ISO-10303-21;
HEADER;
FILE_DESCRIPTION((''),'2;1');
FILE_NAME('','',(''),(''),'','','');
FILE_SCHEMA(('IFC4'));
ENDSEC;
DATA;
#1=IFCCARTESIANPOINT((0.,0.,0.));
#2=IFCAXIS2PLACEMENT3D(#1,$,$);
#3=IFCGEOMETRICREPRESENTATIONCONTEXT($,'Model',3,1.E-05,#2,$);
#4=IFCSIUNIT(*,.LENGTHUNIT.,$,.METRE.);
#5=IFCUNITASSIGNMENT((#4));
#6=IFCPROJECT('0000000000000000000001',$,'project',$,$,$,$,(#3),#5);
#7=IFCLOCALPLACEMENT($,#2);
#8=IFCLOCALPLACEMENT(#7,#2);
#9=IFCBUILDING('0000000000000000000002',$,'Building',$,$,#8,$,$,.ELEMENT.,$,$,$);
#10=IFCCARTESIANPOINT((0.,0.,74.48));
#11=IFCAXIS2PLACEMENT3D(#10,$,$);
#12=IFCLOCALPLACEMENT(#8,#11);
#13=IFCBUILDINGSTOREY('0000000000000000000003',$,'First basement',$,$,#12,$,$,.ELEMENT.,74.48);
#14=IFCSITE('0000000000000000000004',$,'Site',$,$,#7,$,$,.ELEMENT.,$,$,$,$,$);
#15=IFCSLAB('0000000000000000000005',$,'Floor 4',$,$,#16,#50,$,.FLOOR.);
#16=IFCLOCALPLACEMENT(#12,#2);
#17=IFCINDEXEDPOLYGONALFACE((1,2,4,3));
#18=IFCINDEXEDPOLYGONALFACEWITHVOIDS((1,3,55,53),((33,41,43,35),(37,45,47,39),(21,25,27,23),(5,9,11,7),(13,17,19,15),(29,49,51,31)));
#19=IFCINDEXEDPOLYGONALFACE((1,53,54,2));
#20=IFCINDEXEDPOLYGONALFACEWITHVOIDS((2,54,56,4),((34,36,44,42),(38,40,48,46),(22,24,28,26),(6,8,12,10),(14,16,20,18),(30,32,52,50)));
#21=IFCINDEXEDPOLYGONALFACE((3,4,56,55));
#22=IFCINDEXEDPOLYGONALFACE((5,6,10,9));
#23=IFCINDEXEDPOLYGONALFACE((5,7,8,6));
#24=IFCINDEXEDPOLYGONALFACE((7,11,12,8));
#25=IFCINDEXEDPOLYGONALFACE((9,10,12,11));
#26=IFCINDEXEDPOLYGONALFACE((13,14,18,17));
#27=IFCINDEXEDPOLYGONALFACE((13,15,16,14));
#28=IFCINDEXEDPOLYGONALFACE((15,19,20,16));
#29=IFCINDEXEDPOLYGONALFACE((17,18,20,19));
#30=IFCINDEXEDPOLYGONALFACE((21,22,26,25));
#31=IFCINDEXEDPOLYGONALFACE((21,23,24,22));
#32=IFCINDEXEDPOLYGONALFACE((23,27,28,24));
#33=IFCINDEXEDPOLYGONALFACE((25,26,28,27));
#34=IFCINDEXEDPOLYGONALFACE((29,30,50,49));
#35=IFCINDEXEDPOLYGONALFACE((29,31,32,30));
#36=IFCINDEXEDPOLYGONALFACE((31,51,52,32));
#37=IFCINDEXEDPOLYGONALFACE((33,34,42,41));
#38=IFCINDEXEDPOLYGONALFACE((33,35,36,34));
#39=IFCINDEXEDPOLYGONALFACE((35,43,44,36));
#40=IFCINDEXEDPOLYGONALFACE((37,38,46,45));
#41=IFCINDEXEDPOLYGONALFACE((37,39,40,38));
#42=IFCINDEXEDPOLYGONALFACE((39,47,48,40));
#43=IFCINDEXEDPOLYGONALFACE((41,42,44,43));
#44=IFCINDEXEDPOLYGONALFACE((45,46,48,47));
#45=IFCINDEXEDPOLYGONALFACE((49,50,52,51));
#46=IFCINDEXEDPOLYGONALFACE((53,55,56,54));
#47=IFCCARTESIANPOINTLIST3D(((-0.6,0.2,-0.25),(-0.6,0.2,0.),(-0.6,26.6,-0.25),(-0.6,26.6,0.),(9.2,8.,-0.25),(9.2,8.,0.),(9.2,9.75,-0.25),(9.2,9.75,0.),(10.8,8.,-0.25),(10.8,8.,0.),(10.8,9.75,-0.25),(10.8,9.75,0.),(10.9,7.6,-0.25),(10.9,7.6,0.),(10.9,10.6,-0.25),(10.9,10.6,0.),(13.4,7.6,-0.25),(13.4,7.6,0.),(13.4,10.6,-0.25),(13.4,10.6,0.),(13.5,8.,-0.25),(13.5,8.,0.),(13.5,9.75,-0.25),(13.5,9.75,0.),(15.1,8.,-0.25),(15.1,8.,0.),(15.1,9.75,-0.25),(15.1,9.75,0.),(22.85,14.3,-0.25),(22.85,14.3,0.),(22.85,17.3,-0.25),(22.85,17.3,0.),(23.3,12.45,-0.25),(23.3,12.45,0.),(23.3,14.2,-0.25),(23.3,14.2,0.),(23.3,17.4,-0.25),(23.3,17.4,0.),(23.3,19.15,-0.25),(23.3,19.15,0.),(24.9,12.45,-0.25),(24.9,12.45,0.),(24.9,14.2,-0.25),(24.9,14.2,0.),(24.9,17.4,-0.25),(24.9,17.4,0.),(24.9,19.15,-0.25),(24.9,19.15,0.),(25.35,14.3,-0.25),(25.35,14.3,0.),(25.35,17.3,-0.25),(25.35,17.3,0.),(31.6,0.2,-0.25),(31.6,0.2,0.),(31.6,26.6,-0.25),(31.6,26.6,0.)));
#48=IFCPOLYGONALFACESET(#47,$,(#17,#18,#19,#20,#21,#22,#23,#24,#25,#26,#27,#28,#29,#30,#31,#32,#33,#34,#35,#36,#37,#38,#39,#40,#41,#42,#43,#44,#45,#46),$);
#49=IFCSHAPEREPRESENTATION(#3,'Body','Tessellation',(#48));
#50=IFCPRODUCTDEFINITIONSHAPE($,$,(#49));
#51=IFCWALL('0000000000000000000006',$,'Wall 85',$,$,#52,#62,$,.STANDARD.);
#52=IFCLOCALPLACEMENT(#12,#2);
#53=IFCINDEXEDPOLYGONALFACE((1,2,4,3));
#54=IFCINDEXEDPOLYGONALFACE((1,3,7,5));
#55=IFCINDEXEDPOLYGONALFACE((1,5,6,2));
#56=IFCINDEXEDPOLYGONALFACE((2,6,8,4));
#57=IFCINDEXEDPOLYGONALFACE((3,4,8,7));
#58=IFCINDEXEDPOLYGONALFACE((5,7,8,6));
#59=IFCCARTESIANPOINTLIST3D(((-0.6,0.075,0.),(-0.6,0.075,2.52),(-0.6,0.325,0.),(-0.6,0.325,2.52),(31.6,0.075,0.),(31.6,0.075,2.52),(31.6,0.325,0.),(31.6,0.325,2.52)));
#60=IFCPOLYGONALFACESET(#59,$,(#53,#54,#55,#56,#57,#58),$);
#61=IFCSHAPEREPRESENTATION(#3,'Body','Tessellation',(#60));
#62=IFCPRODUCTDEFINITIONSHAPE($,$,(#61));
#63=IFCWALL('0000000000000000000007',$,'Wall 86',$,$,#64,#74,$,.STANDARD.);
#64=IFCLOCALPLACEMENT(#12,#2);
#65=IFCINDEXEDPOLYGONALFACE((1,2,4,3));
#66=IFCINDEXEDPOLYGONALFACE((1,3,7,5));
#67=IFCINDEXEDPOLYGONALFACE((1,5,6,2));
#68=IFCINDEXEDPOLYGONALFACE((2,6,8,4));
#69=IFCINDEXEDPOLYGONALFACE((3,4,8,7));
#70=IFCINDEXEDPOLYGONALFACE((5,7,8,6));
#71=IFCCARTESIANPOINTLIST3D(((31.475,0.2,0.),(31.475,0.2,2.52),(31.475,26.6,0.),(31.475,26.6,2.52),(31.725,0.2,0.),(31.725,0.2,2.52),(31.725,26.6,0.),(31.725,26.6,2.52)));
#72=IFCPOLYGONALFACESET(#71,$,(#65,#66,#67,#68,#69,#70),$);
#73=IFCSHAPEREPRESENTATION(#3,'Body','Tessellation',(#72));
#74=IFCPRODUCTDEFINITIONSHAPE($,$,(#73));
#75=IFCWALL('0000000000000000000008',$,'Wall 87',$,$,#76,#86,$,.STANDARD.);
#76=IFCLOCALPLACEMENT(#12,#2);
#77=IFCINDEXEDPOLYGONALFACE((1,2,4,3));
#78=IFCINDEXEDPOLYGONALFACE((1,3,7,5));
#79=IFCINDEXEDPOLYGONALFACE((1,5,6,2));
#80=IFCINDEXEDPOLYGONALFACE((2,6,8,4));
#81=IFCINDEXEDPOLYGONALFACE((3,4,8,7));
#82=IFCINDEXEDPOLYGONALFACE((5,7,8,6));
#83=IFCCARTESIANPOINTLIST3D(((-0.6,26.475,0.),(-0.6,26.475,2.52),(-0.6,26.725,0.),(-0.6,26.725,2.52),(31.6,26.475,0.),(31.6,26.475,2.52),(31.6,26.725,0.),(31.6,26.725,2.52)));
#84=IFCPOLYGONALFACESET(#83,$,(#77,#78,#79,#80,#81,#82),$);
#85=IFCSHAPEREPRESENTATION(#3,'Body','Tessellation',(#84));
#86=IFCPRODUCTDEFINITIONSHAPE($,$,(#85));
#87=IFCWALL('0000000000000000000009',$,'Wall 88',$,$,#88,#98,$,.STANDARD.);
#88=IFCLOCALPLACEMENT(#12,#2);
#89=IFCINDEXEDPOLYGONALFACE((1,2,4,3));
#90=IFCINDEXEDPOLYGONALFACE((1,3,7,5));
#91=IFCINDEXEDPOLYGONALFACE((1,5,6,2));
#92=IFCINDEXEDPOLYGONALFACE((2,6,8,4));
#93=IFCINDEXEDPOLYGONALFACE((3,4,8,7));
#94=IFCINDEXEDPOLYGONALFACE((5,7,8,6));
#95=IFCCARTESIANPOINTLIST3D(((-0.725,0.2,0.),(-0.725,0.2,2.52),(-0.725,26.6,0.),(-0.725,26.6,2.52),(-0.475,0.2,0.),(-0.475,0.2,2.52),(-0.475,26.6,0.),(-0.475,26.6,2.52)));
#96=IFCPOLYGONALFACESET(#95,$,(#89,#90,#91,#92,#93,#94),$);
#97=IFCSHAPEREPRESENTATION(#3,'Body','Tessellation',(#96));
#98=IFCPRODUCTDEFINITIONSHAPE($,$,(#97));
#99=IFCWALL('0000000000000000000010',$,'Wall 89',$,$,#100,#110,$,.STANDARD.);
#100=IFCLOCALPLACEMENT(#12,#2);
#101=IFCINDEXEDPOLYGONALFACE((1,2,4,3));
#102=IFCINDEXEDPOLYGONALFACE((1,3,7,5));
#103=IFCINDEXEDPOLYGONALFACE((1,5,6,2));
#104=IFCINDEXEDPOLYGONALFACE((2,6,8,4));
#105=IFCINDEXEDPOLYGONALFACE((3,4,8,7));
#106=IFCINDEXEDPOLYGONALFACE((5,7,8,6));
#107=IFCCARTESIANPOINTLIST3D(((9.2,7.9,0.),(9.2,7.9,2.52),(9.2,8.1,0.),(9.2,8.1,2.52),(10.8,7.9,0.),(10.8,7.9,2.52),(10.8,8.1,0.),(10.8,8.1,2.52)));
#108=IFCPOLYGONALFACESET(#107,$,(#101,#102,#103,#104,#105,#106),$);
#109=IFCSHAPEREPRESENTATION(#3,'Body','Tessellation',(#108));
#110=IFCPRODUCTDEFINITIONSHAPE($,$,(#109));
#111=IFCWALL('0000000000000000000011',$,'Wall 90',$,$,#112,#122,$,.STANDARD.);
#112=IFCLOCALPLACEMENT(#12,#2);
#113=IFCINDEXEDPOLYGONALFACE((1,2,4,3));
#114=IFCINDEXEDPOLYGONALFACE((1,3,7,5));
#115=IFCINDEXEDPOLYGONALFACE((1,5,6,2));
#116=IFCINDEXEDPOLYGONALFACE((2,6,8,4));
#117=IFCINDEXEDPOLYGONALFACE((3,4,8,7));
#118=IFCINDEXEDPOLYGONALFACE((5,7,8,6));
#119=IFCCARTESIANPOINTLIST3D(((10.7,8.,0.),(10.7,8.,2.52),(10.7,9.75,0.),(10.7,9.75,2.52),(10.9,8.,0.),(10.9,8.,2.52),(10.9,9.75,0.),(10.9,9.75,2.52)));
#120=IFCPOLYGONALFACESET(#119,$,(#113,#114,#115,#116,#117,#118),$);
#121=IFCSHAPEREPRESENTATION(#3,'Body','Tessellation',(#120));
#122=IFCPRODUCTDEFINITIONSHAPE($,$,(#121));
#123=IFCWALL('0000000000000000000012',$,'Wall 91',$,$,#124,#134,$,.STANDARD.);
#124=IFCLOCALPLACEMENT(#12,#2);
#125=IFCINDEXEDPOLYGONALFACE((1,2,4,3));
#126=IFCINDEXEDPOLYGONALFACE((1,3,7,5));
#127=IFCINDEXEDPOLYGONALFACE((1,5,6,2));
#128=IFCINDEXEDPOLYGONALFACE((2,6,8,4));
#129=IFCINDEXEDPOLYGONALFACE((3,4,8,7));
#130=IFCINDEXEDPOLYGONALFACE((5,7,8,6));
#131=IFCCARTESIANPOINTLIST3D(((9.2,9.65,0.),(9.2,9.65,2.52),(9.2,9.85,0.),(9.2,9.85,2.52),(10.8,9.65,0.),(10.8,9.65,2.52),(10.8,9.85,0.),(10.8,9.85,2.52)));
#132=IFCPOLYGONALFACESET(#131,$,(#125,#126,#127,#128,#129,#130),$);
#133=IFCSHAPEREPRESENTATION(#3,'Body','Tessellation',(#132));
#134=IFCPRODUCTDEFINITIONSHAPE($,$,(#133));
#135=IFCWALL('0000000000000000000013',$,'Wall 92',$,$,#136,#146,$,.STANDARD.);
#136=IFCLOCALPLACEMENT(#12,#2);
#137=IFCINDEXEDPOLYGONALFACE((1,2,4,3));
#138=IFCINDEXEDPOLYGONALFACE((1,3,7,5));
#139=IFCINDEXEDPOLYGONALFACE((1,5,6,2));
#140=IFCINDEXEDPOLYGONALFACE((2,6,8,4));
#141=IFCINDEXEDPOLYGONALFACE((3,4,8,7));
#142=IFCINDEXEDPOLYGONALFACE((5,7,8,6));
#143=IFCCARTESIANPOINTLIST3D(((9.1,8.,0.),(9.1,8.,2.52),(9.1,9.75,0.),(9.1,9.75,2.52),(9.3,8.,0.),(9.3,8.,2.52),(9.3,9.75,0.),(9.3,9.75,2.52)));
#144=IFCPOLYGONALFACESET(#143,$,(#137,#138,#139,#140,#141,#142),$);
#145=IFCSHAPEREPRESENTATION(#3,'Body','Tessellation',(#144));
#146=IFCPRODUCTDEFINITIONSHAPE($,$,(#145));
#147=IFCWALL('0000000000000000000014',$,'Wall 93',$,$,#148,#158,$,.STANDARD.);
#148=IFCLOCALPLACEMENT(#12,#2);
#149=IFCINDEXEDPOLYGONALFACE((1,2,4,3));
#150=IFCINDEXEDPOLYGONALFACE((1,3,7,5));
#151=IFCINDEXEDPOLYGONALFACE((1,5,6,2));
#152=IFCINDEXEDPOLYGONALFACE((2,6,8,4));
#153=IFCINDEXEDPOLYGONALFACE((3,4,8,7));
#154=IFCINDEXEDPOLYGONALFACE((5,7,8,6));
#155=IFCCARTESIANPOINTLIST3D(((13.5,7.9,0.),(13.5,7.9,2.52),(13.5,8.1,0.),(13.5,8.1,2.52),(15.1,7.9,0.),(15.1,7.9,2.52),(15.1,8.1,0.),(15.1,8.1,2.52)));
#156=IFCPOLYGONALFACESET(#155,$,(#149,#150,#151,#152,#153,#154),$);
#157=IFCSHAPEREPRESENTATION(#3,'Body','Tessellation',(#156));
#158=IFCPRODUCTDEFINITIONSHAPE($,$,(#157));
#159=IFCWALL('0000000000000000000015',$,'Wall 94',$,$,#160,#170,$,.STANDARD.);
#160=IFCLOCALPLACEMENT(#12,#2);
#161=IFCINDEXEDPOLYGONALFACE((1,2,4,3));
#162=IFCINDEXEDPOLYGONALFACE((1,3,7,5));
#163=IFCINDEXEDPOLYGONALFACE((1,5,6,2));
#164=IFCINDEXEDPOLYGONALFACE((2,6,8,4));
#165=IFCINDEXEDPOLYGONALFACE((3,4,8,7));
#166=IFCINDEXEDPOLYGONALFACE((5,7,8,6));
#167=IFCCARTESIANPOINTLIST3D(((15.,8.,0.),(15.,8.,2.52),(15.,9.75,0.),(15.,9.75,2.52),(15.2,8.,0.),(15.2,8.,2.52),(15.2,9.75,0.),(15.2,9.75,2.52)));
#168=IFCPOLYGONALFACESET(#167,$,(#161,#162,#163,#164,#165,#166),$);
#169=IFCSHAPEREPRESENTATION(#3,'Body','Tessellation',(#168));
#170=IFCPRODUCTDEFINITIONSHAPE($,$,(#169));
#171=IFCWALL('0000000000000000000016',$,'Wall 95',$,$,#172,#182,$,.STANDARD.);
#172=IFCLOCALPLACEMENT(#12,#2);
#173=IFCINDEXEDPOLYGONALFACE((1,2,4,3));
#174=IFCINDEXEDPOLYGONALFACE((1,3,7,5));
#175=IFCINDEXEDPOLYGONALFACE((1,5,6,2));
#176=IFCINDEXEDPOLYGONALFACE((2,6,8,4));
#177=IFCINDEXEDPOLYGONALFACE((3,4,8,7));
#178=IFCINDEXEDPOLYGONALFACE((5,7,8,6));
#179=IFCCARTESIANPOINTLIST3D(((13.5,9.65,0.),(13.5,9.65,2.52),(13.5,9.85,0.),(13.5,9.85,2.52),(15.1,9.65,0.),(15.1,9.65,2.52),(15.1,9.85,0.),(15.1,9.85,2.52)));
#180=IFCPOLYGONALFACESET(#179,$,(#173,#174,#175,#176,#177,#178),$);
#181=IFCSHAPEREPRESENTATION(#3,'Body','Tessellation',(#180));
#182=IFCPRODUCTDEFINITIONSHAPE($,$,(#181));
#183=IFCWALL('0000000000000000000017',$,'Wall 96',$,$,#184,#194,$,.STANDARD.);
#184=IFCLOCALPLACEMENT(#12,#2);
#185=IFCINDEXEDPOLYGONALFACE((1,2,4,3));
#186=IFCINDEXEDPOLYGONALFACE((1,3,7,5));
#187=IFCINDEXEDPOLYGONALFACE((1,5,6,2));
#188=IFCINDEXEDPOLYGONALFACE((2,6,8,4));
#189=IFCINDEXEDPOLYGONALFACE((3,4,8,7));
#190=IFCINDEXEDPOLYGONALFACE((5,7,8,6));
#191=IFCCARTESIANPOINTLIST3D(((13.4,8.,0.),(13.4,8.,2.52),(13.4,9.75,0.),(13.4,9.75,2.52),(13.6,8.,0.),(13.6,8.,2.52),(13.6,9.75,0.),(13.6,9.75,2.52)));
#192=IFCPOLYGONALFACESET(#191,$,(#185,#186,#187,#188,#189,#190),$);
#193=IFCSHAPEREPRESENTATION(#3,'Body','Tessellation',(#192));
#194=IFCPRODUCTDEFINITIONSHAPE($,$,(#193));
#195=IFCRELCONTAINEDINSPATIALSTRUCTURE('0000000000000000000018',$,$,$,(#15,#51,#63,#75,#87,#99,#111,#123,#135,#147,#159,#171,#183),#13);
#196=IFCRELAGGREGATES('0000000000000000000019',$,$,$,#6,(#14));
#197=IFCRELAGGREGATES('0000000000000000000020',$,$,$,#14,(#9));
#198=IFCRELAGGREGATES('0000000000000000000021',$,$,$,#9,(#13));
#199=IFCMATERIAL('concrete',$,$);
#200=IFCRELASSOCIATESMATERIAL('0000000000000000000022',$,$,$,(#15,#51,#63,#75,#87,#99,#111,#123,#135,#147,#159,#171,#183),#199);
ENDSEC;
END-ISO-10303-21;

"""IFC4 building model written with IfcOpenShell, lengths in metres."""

from ifc_helpers import new_model, si_unit, frame, frame_2d, origin, place, context, project, spatial, polyline, rectangle, outline, extrude, material, element, save


model = new_model("IFC4")

# Units and contexts
model_context = context("Model", 3, precision=1e-05, world=origin())
ifc_project = project(units=[si_unit("LENGTHUNIT", "METRE")], contexts=[model_context])

# Site, building, storey
site_placement = place(None, origin())
site = spatial("IfcSite", under=ifc_project, at=site_placement, Name="Site", CompositionType="ELEMENT")
building_placement = place(site_placement, origin())
building = spatial("IfcBuilding", under=site, at=building_placement, Name="Building", CompositionType="ELEMENT")
storey_placement = place(building_placement, frame((0.0, 0.0, 74.48)))
storey = spatial("IfcBuildingStorey", under=building, at=storey_placement, Name="First basement", CompositionType="ELEMENT", Elevation=74.48)

# Slab
ifc_material = material(Name="concrete")
slab_placement = place(storey_placement, frame((0.0, 0.0, -0.25), z_axis=(0.0, 0.0, 1.0), x_axis=(1.0, 0.0, 0.0)))
element("IfcSlab", 1, at=slab_placement, inside=storey, material=ifc_material, Name="Floor 4", PredefinedType="FLOOR", context=model_context, shape_type="SweptSolid", body=[
    extrude(outline(polyline([(-0.6, 0.2), (31.6, 0.2), (31.6, 26.6), (-0.6, 26.6), (-0.6, 0.2)]), holes=[polyline([(10.9, 7.6), (13.4, 7.6), (13.4, 10.6), (10.9, 10.6), (10.9, 7.6)]), polyline([(9.2, 8.0), (10.8, 8.0), (10.8, 9.75), (9.2, 9.75), (9.2, 8.0)]), polyline([(13.5, 8.0), (15.1, 8.0), (15.1, 9.75), (13.5, 9.75), (13.5, 8.0)]), polyline([(22.85, 14.3), (25.35, 14.3), (25.35, 17.3), (22.85, 17.3), (22.85, 14.3)]), polyline([(23.3, 17.4), (24.9, 17.4), (24.9, 19.15), (23.3, 19.15), (23.3, 17.4)]), polyline([(23.3, 12.45), (24.9, 12.45), (24.9, 14.2), (23.3, 14.2), (23.3, 12.45)])]), origin(), (0.0, 0.0, 1.0), 0.25),
])

# Walls
wall_1_placement = place(storey_placement, frame((-0.6, 0.2, 0.0), z_axis=(0.0, 0.0, 1.0), x_axis=(1.0, 0.0, 0.0)))
element("IfcWall", 2, at=wall_1_placement, inside=storey, material=ifc_material, Name="Wall 85", PredefinedType="STANDARD", context=model_context, shape_type="SweptSolid", body=[
    extrude(rectangle(XDim=32.2, YDim=0.25, at=frame_2d((16.1, 0.0))), origin(), (0.0, 0.0, 1.0), 2.52),
])
wall_2_placement = place(storey_placement, frame((31.6, 0.2, 0.0), z_axis=(0.0, 0.0, 1.0), x_axis=(0.0, 1.0, 0.0)))
element("IfcWall", 3, at=wall_2_placement, inside=storey, material=ifc_material, Name="Wall 86", PredefinedType="STANDARD", context=model_context, shape_type="SweptSolid", body=[
    extrude(rectangle(XDim=26.4, YDim=0.25, at=frame_2d((13.2, 0.0))), origin(), (0.0, 0.0, 1.0), 2.52),
])
wall_3_placement = place(storey_placement, frame((31.6, 26.6, 0.0), z_axis=(0.0, 0.0, 1.0), x_axis=(-1.0, 0.0, 0.0)))
element("IfcWall", 4, at=wall_3_placement, inside=storey, material=ifc_material, Name="Wall 87", PredefinedType="STANDARD", context=model_context, shape_type="SweptSolid", body=[
    extrude(rectangle(XDim=32.2, YDim=0.25, at=frame_2d((16.1, 0.0))), origin(), (0.0, 0.0, 1.0), 2.52),
])
wall_4_placement = place(storey_placement, frame((-0.6, 26.6, 0.0), z_axis=(0.0, 0.0, 1.0), x_axis=(0.0, -1.0, 0.0)))
element("IfcWall", 5, at=wall_4_placement, inside=storey, material=ifc_material, Name="Wall 88", PredefinedType="STANDARD", context=model_context, shape_type="SweptSolid", body=[
    extrude(rectangle(XDim=26.4, YDim=0.25, at=frame_2d((13.2, 0.0))), origin(), (0.0, 0.0, 1.0), 2.52),
])
wall_5_placement = place(storey_placement, frame((9.2, 8.0, 0.0), z_axis=(0.0, 0.0, 1.0), x_axis=(1.0, 0.0, 0.0)))
element("IfcWall", 6, at=wall_5_placement, inside=storey, material=ifc_material, Name="Wall 89", PredefinedType="STANDARD", context=model_context, shape_type="SweptSolid", body=[
    extrude(rectangle(XDim=1.6, YDim=0.2, at=frame_2d((0.8, 0.0))), origin(), (0.0, 0.0, 1.0), 2.52),
])
wall_6_placement = place(storey_placement, frame((10.8, 8.0, 0.0), z_axis=(0.0, 0.0, 1.0), x_axis=(0.0, 1.0, 0.0)))
element("IfcWall", 7, at=wall_6_placement, inside=storey, material=ifc_material, Name="Wall 90", PredefinedType="STANDARD", context=model_context, shape_type="SweptSolid", body=[
    extrude(rectangle(XDim=1.75, YDim=0.2, at=frame_2d((0.875, 0.0))), origin(), (0.0, 0.0, 1.0), 2.52),
])
wall_7_placement = place(storey_placement, frame((10.8, 9.75, 0.0), z_axis=(0.0, 0.0, 1.0), x_axis=(-1.0, 0.0, 0.0)))
element("IfcWall", 8, at=wall_7_placement, inside=storey, material=ifc_material, Name="Wall 91", PredefinedType="STANDARD", context=model_context, shape_type="SweptSolid", body=[
    extrude(rectangle(XDim=1.6, YDim=0.2, at=frame_2d((0.8, 0.0))), origin(), (0.0, 0.0, 1.0), 2.52),
])
wall_8_placement = place(storey_placement, frame((9.2, 9.75, 0.0), z_axis=(0.0, 0.0, 1.0), x_axis=(0.0, -1.0, 0.0)))
element("IfcWall", 9, at=wall_8_placement, inside=storey, material=ifc_material, Name="Wall 92", PredefinedType="STANDARD", context=model_context, shape_type="SweptSolid", body=[
    extrude(rectangle(XDim=1.75, YDim=0.2, at=frame_2d((0.875, 0.0))), origin(), (0.0, 0.0, 1.0), 2.52),
])
wall_9_placement = place(storey_placement, frame((13.5, 8.0, 0.0), z_axis=(0.0, 0.0, 1.0), x_axis=(1.0, 0.0, 0.0)))
element("IfcWall", 10, at=wall_9_placement, inside=storey, material=ifc_material, Name="Wall 93", PredefinedType="STANDARD", context=model_context, shape_type="SweptSolid", body=[
    extrude(rectangle(XDim=1.6, YDim=0.2, at=frame_2d((0.8, 0.0))), origin(), (0.0, 0.0, 1.0), 2.52),
])
wall_10_placement = place(storey_placement, frame((15.1, 8.0, 0.0), z_axis=(0.0, 0.0, 1.0), x_axis=(0.0, 1.0, 0.0)))
element("IfcWall", 11, at=wall_10_placement, inside=storey, material=ifc_material, Name="Wall 94", PredefinedType="STANDARD", context=model_context, shape_type="SweptSolid", body=[
    extrude(rectangle(XDim=1.75, YDim=0.2, at=frame_2d((0.875, 0.0))), origin(), (0.0, 0.0, 1.0), 2.52),
])
wall_11_placement = place(storey_placement, frame((15.1, 9.75, 0.0), z_axis=(0.0, 0.0, 1.0), x_axis=(-1.0, 0.0, 0.0)))
element("IfcWall", 12, at=wall_11_placement, inside=storey, material=ifc_material, Name="Wall 95", PredefinedType="STANDARD", context=model_context, shape_type="SweptSolid", body=[
    extrude(rectangle(XDim=1.6, YDim=0.2, at=frame_2d((0.8, 0.0))), origin(), (0.0, 0.0, 1.0), 2.52),
])
wall_12_placement = place(storey_placement, frame((13.5, 9.75, 0.0), z_axis=(0.0, 0.0, 1.0), x_axis=(0.0, -1.0, 0.0)))
element("IfcWall", 13, at=wall_12_placement, inside=storey, material=ifc_material, Name="Wall 96", PredefinedType="STANDARD", context=model_context, shape_type="SweptSolid", body=[
    extrude(rectangle(XDim=1.75, YDim=0.2, at=frame_2d((0.875, 0.0))), origin(), (0.0, 0.0, 1.0), 2.52),
])

save(model, "model.ifc")
